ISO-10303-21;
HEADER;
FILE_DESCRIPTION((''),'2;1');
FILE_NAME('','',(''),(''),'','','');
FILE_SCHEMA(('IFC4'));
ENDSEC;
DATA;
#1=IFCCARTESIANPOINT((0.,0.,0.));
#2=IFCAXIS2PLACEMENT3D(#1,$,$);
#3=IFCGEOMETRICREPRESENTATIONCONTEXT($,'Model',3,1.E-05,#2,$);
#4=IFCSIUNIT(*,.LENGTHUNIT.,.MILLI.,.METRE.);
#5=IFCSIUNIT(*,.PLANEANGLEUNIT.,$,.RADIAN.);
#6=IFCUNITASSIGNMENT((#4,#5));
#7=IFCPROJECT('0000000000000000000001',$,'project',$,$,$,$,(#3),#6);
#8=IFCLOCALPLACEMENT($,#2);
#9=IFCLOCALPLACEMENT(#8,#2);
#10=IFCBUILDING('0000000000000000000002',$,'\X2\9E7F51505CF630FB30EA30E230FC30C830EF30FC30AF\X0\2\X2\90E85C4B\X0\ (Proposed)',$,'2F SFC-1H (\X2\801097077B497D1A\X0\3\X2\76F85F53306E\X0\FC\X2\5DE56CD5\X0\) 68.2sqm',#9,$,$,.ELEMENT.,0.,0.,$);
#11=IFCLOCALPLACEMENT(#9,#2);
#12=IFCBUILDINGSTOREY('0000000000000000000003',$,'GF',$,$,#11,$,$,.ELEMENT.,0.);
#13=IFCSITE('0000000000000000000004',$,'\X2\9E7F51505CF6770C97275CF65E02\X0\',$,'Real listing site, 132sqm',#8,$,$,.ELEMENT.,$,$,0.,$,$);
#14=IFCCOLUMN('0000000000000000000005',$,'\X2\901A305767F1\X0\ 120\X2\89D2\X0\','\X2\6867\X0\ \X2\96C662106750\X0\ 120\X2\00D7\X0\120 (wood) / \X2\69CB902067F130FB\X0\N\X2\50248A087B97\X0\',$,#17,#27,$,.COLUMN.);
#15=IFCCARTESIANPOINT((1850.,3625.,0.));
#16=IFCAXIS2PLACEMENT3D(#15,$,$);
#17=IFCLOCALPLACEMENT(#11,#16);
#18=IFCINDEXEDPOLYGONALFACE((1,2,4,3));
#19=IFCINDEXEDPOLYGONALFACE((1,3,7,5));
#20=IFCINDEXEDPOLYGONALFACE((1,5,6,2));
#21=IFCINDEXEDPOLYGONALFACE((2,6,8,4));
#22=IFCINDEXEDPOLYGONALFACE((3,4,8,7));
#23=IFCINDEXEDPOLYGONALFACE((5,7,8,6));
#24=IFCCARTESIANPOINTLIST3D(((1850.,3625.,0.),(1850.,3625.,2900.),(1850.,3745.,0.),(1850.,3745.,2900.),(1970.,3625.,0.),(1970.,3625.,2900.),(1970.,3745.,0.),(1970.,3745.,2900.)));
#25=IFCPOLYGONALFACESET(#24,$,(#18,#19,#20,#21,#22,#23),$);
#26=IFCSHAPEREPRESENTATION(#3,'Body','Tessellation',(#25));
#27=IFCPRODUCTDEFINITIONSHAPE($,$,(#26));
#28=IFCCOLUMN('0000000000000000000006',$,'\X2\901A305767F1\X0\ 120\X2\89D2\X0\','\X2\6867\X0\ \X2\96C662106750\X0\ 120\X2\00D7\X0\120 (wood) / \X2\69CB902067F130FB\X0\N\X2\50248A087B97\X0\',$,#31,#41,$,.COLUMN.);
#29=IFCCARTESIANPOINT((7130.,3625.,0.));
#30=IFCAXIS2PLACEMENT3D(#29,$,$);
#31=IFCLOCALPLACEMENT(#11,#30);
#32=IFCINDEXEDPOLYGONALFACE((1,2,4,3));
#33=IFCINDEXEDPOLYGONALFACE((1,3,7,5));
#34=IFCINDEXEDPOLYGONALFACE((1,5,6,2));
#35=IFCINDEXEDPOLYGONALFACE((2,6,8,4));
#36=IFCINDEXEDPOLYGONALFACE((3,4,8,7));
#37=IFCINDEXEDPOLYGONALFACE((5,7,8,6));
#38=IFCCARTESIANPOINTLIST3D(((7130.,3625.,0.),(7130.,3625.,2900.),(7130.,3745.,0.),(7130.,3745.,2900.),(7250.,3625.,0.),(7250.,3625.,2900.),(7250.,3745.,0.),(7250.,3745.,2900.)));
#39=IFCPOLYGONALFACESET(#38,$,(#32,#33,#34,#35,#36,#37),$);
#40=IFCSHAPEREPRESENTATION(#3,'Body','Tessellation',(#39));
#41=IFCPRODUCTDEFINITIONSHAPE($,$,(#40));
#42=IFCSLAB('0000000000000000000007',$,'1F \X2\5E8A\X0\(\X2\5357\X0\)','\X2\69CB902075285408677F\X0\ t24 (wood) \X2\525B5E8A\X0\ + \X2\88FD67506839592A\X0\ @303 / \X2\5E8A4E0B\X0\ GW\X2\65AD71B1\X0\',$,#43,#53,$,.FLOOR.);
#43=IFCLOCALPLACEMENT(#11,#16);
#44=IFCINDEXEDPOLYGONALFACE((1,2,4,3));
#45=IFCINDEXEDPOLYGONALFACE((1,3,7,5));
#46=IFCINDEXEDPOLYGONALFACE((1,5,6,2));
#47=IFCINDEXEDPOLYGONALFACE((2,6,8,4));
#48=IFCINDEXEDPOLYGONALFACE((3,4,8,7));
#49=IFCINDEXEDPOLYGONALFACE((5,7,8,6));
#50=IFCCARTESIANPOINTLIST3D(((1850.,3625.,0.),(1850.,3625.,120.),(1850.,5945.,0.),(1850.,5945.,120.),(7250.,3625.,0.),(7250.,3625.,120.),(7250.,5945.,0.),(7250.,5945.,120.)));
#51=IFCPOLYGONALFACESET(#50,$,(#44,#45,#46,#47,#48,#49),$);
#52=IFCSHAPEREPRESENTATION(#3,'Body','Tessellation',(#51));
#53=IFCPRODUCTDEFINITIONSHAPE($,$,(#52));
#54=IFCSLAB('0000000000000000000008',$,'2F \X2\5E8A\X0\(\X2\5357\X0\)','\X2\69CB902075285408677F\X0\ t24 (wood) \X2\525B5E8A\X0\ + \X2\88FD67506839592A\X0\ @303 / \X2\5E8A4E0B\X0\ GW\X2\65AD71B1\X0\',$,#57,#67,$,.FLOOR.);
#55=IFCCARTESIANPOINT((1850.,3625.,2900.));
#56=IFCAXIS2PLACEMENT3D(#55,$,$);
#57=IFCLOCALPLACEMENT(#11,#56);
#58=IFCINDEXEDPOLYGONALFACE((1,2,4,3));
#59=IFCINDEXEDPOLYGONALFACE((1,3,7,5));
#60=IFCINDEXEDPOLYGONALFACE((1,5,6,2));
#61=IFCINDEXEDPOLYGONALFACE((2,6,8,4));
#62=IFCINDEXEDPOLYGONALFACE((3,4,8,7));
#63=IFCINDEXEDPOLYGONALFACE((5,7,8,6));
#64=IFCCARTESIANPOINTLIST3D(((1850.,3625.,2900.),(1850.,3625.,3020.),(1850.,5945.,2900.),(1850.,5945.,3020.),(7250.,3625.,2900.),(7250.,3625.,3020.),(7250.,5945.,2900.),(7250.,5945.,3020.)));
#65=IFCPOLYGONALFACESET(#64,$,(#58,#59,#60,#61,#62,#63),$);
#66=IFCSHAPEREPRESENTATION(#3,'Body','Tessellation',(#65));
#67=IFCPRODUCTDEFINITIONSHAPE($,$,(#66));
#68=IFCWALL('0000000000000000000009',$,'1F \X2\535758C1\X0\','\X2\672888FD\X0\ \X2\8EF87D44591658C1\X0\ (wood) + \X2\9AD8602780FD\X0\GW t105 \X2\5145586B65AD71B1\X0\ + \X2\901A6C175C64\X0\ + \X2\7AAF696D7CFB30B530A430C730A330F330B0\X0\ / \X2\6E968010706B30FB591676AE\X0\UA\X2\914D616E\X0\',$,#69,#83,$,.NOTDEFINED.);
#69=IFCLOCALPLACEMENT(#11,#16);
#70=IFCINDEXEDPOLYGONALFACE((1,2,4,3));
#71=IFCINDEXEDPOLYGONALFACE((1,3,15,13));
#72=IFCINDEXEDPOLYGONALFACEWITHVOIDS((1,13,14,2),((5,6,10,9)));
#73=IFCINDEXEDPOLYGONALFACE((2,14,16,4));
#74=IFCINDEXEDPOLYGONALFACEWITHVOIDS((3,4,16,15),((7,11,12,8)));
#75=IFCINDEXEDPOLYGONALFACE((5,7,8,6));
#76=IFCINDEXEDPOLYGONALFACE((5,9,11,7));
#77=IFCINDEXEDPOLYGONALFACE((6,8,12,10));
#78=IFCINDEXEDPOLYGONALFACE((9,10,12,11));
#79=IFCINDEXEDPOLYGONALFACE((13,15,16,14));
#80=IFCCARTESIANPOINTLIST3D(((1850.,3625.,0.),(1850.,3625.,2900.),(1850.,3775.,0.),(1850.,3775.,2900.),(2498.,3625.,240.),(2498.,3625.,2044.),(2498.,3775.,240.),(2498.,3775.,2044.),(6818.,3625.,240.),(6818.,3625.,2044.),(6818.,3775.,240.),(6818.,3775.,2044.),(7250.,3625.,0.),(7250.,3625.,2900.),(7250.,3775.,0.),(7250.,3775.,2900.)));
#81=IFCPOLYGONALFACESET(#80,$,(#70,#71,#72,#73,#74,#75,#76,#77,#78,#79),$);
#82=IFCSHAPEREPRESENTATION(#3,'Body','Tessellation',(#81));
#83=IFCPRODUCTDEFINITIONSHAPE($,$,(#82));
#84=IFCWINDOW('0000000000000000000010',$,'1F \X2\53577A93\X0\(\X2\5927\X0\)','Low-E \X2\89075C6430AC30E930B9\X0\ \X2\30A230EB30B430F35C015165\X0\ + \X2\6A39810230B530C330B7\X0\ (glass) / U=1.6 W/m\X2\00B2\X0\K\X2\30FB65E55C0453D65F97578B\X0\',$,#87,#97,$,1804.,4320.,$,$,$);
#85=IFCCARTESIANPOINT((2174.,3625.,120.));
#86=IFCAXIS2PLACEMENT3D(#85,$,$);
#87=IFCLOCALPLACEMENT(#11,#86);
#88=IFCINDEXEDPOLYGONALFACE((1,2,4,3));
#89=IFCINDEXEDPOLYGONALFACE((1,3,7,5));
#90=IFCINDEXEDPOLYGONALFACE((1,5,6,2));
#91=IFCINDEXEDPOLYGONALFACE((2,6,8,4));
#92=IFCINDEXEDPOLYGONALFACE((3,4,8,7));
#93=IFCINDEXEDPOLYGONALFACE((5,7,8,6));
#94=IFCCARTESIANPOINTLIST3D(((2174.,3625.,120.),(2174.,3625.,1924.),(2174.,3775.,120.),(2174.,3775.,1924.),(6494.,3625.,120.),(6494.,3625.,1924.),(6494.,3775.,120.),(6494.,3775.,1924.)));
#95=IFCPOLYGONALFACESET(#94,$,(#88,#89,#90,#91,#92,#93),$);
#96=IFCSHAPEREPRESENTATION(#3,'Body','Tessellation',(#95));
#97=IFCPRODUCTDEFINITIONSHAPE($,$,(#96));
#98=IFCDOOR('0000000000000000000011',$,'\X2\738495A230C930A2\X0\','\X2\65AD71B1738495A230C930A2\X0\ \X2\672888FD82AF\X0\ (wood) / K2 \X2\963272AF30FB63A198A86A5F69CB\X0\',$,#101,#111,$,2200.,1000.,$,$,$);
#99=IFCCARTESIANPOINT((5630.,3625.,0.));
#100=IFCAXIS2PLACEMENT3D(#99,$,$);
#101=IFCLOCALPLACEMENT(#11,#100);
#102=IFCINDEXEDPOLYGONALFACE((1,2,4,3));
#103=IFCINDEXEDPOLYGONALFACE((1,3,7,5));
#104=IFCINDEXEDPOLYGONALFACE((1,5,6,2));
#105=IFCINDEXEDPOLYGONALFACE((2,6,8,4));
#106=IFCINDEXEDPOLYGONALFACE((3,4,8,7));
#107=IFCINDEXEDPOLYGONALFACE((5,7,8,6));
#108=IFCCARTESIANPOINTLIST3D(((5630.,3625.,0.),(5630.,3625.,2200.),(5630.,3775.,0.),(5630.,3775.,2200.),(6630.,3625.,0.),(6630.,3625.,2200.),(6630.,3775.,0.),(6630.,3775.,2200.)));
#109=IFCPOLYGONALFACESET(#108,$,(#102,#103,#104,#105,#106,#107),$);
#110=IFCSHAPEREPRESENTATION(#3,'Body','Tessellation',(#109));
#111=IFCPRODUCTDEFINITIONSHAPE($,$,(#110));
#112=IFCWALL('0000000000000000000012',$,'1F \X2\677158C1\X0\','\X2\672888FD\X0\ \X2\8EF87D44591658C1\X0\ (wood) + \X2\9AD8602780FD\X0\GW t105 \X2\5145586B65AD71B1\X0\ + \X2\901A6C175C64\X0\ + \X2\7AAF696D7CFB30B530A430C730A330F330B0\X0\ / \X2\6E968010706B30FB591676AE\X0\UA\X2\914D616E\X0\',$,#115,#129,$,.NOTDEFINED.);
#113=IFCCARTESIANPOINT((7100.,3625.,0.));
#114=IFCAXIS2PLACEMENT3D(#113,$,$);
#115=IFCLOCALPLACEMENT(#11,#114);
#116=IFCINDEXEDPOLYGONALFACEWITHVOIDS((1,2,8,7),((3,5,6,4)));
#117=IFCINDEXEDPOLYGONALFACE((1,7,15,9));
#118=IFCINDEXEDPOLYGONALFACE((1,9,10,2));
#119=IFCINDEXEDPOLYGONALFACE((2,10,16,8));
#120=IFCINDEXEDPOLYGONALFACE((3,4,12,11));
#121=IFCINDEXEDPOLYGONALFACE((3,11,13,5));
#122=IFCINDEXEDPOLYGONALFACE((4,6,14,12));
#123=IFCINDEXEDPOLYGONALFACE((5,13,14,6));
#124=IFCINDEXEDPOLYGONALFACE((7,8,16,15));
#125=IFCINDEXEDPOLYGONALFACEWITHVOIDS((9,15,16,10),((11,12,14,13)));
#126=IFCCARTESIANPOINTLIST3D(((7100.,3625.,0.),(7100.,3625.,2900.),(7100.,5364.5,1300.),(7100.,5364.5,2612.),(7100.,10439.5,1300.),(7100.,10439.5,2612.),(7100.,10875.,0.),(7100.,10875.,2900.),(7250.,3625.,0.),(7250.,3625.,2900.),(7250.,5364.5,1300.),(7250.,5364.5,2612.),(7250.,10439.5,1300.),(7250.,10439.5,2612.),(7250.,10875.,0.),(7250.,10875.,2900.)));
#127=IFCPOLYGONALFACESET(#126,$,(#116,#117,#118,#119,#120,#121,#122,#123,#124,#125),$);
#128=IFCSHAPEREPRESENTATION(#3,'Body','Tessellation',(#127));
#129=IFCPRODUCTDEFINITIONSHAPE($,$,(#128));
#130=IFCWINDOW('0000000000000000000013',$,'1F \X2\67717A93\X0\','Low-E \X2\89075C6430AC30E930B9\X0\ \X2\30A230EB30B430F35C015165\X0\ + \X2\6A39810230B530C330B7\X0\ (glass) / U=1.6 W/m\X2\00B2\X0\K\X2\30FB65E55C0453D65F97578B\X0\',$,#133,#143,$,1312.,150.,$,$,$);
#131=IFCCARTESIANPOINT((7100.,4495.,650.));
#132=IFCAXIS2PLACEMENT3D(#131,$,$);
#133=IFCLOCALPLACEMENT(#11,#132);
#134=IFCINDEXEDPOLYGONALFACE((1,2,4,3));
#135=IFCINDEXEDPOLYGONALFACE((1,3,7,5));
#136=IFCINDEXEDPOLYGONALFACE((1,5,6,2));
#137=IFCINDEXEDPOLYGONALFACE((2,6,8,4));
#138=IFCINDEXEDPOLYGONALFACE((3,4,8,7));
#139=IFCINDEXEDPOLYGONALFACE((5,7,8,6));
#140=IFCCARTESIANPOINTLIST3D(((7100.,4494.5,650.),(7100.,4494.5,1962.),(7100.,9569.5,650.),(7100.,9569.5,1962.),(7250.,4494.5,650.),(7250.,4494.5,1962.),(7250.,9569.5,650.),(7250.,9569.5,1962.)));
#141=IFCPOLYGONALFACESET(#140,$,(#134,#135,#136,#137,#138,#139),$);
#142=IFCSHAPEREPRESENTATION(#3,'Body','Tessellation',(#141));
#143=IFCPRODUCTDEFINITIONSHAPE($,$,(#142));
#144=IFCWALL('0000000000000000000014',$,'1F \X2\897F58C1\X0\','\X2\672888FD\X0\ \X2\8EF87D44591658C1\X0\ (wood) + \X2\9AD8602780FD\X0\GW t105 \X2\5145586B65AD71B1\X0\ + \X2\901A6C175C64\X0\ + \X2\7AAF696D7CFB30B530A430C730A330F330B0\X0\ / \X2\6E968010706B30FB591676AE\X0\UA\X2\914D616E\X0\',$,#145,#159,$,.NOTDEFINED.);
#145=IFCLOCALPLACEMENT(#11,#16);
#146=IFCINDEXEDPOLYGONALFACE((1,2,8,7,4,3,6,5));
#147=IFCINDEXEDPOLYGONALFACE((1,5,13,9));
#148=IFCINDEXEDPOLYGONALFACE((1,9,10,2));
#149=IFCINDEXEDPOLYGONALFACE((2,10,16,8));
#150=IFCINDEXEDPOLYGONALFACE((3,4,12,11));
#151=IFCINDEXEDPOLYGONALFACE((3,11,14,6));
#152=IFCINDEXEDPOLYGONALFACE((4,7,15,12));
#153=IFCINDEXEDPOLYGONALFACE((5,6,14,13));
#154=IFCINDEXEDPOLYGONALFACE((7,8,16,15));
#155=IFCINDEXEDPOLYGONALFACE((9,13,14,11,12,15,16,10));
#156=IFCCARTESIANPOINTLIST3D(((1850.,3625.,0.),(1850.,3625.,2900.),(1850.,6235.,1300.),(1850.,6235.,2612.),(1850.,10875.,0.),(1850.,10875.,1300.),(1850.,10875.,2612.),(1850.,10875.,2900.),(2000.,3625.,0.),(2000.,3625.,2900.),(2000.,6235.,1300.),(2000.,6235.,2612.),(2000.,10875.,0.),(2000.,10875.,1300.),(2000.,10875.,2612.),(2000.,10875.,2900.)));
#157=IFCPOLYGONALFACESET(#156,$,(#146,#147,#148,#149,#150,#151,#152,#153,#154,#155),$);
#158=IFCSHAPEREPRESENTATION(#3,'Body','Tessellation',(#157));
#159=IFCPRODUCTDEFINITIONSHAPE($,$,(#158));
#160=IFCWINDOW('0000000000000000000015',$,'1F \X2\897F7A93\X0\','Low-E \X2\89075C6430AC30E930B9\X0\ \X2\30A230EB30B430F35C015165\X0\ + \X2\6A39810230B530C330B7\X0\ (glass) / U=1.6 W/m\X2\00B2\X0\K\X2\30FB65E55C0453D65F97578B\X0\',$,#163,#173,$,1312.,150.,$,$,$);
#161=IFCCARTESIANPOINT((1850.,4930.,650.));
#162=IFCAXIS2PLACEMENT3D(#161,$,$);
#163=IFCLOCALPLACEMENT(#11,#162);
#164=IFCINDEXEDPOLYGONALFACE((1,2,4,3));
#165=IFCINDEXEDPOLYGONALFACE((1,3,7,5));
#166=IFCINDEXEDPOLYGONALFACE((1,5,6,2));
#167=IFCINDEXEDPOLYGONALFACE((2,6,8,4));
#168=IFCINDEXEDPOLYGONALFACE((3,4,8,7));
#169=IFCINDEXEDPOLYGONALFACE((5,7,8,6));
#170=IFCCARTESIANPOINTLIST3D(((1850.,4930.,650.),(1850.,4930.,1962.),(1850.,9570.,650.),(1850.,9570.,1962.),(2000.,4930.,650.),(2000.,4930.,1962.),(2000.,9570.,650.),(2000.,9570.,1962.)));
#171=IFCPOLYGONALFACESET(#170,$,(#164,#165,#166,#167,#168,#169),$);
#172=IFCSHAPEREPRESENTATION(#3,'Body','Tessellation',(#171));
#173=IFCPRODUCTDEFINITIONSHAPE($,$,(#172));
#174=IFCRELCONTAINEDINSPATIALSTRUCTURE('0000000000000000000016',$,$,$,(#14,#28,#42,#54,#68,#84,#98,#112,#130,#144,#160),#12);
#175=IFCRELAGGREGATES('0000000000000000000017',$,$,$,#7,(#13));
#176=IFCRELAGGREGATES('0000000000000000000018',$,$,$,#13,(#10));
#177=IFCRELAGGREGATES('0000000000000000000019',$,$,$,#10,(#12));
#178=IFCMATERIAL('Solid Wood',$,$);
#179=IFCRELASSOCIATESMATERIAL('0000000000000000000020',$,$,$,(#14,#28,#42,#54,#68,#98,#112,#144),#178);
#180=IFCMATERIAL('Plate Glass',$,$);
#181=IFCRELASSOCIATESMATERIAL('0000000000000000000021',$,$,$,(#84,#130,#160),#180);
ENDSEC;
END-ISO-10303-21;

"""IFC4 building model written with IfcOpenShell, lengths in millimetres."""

from ifc_helpers import new_model, si_unit, frame, frame_2d, origin, place, context, project, spatial, rectangle, extrude, material, element, fill, save


model = new_model("IFC4")

# Units and contexts
model_context = context("Model", 3, precision=1e-05, world=origin())
ifc_project = project(units=[si_unit("LENGTHUNIT", "METRE", prefix="MILLI"), si_unit("PLANEANGLEUNIT", "RADIAN")], contexts=[model_context])

# Site, building, storey
site_placement = place(None, origin())
site = spatial("IfcSite", under=ifc_project, at=site_placement, Name="鹿児島県霧島市", ObjectType="Real listing site, 132sqm", CompositionType="ELEMENT", RefElevation=0.0)
building_placement = place(site_placement, origin())
building = spatial("IfcBuilding", under=site, at=building_placement, Name="鹿児島・リモートワーク2部屋 (Proposed)", ObjectType="2F SFC-1H (耐震等級3相当のFC工法) 68.2sqm", CompositionType="ELEMENT", ElevationOfRefHeight=0.0, ElevationOfTerrain=0.0)
storey_placement = place(building_placement, origin())
storey = spatial("IfcBuildingStorey", under=building, at=storey_placement, Name="GF", CompositionType="ELEMENT", Elevation=0.0)

# Columns
ifc_material_1 = material(Name="Solid Wood")
column_1_placement = place(storey_placement, frame((1850.0, 3625.0, 0.0)))
element("IfcColumn", 1, at=column_1_placement, inside=storey, material=ifc_material_1, Name="通し柱 120角", Description="桧 集成材 120×120 (wood) / 構造柱・N値計算", PredefinedType="COLUMN", context=model_context, shape_type="SweptSolid", body=[
    extrude(rectangle(XDim=120.0, YDim=120.0, at=frame_2d((60.0, 60.0))), frame((1850.0, 3625.0, 0.0)), (0.0, 0.0, 1.0), 2900.0),
])
column_2_placement = place(storey_placement, frame((7130.0, 3625.0, 0.0)))
element("IfcColumn", 2, at=column_2_placement, inside=storey, material=ifc_material_1, Name="通し柱 120角", Description="桧 集成材 120×120 (wood) / 構造柱・N値計算", PredefinedType="COLUMN", context=model_context, shape_type="SweptSolid", body=[
    extrude(rectangle(XDim=120.0, YDim=120.0, at=frame_2d((60.0, 60.0))), frame((7130.0, 3625.0, 0.0)), (0.0, 0.0, 1.0), 2900.0),
])

# Slabs
slab_1_placement = place(storey_placement, frame((1850.0, 3625.0, 0.0)))
element("IfcSlab", 3, at=slab_1_placement, inside=storey, material=ifc_material_1, Name="1F 床(南)", Description="構造用合板 t24 (wood) 剛床 + 製材根太 @303 / 床下 GW断熱", PredefinedType="FLOOR", context=model_context, shape_type="SweptSolid", body=[
    extrude(rectangle(XDim=5400.0, YDim=2320.0, at=frame_2d((2700.0, 1160.0))), frame((1850.0, 3625.0, 0.0)), (0.0, 0.0, 1.0), 120.0),
])
slab_2_placement = place(storey_placement, frame((1850.0, 3625.0, 2900.0)))
element("IfcSlab", 4, at=slab_2_placement, inside=storey, material=ifc_material_1, Name="2F 床(南)", Description="構造用合板 t24 (wood) 剛床 + 製材根太 @303 / 床下 GW断熱", PredefinedType="FLOOR", context=model_context, shape_type="SweptSolid", body=[
    extrude(rectangle(XDim=5400.0, YDim=2320.0, at=frame_2d((2700.0, 1160.0))), frame((1850.0, 3625.0, 2900.0)), (0.0, 0.0, 1.0), 120.0),
])

# Wall, openings, window, door
wall_1_placement = place(storey_placement, frame((1850.0, 3625.0, 0.0)))
wall_1 = element("IfcWall", 5, at=wall_1_placement, inside=storey, material=ifc_material_1, Name="1F 南壁", Description="木製 軸組外壁 (wood) + 高性能GW t105 充填断熱 + 通気層 + 窯業系サイディング / 準耐火・外皮UA配慮", PredefinedType="NOTDEFINED", context=model_context, shape_type="SweptSolid", body=[
    extrude(rectangle(XDim=5400.0, YDim=150.0, at=frame_2d((2700.0, 75.0))), frame((1850.0, 3625.0, 0.0)), (0.0, 0.0, 1.0), 2900.0),
])
opening_1_placement = place(storey_placement, frame((2174.0, 3625.0, 120.0)))
opening_1 = element("IfcOpeningElement", 6, at=opening_1_placement, cuts=wall_1, PredefinedType="NOTDEFINED", context=model_context, shape_type="SweptSolid", body=[
    extrude(rectangle(XDim=4320.0, YDim=150.0, at=frame_2d((2160.0, 75.0))), frame((2174.0, 3625.0, 120.0)), (0.0, 0.0, 1.0), 1804.0),
])
opening_2_placement = place(storey_placement, frame((5630.0, 3625.0, 0.0)))
opening_2 = element("IfcOpeningElement", 7, at=opening_2_placement, cuts=wall_1, PredefinedType="NOTDEFINED", context=model_context, shape_type="SweptSolid", body=[
    extrude(rectangle(XDim=1000.0, YDim=150.0, at=frame_2d((500.0, 75.0))), frame((5630.0, 3625.0, 0.0)), (0.0, 0.0, 1.0), 2200.0),
])
ifc_material_2 = material(Name="Plate Glass")
window_1_placement = place(storey_placement, frame((2174.0, 3625.0, 120.0)))
window_1 = element("IfcWindow", 8, at=window_1_placement, inside=storey, material=ifc_material_2, Name="1F 南窓(大)", Description="Low-E 複層ガラス アルゴン封入 + 樹脂サッシ (glass) / U=1.6 W/m²K・日射取得型", OverallHeight=1804.0, OverallWidth=4320.0, context=model_context, shape_type="SweptSolid", body=[
    extrude(rectangle(XDim=4320.0, YDim=150.0, at=frame_2d((2160.0, 75.0))), frame((2174.0, 3625.0, 120.0)), (0.0, 0.0, 1.0), 1804.0),
])
fill(opening_1, window_1)
door_placement = place(storey_placement, frame((5630.0, 3625.0, 0.0)))
door = element("IfcDoor", 9, at=door_placement, inside=storey, material=ifc_material_1, Name="玄関ドア", Description="断熱玄関ドア 木製芯 (wood) / K2 防犯・採風機構", OverallHeight=2200.0, OverallWidth=1000.0, context=model_context, shape_type="SweptSolid", body=[
    extrude(rectangle(XDim=1000.0, YDim=150.0, at=frame_2d((500.0, 75.0))), frame((5630.0, 3625.0, 0.0)), (0.0, 0.0, 1.0), 2200.0),
])
fill(opening_2, door)

# Walls, openings, windows
wall_2_placement = place(storey_placement, frame((7100.0, 3625.0, 0.0)))
wall_2 = element("IfcWall", 10, at=wall_2_placement, inside=storey, material=ifc_material_1, Name="1F 東壁", Description="木製 軸組外壁 (wood) + 高性能GW t105 充填断熱 + 通気層 + 窯業系サイディング / 準耐火・外皮UA配慮", PredefinedType="NOTDEFINED", context=model_context, shape_type="SweptSolid", body=[
    extrude(rectangle(XDim=150.0, YDim=7250.0, at=frame_2d((75.0, 3625.0))), frame((7100.0, 3625.0, 0.0)), (0.0, 0.0, 1.0), 2900.0),
])
opening_3_placement = place(storey_placement, frame((7100.0, 4495.0, 650.0)))
opening_3 = element("IfcOpeningElement", 11, at=opening_3_placement, cuts=wall_2, PredefinedType="NOTDEFINED", context=model_context, shape_type="SweptSolid", body=[
    extrude(rectangle(XDim=150.0, YDim=5075.0, at=frame_2d((75.0, 2537.0))), frame((7100.0, 4495.0, 650.0)), (0.0, 0.0, 1.0), 1312.0),
])
window_2_placement = place(storey_placement, frame((7100.0, 4495.0, 650.0)))
window_2 = element("IfcWindow", 12, at=window_2_placement, inside=storey, material=ifc_material_2, Name="1F 東窓", Description="Low-E 複層ガラス アルゴン封入 + 樹脂サッシ (glass) / U=1.6 W/m²K・日射取得型", OverallHeight=1312.0, OverallWidth=150.0, context=model_context, shape_type="SweptSolid", body=[
    extrude(rectangle(XDim=150.0, YDim=5075.0, at=frame_2d((75.0, 2537.0))), frame((7100.0, 4495.0, 650.0)), (0.0, 0.0, 1.0), 1312.0),
])
fill(opening_3, window_2)
wall_3_placement = place(storey_placement, frame((1850.0, 3625.0, 0.0)))
wall_3 = element("IfcWall", 13, at=wall_3_placement, inside=storey, material=ifc_material_1, Name="1F 西壁", Description="木製 軸組外壁 (wood) + 高性能GW t105 充填断熱 + 通気層 + 窯業系サイディング / 準耐火・外皮UA配慮", PredefinedType="NOTDEFINED", context=model_context, shape_type="SweptSolid", body=[
    extrude(rectangle(XDim=150.0, YDim=7250.0, at=frame_2d((75.0, 3625.0))), frame((1850.0, 3625.0, 0.0)), (0.0, 0.0, 1.0), 2900.0),
])
opening_4_placement = place(storey_placement, frame((1850.0, 4930.0, 650.0)))
opening_4 = element("IfcOpeningElement", 14, at=opening_4_placement, cuts=wall_3, PredefinedType="NOTDEFINED", context=model_context, shape_type="SweptSolid", body=[
    extrude(rectangle(XDim=150.0, YDim=4640.0, at=frame_2d((75.0, 2320.0))), frame((1850.0, 4930.0, 650.0)), (0.0, 0.0, 1.0), 1312.0),
])
window_3_placement = place(storey_placement, frame((1850.0, 4930.0, 650.0)))
window_3 = element("IfcWindow", 15, at=window_3_placement, inside=storey, material=ifc_material_2, Name="1F 西窓", Description="Low-E 複層ガラス アルゴン封入 + 樹脂サッシ (glass) / U=1.6 W/m²K・日射取得型", OverallHeight=1312.0, OverallWidth=150.0, context=model_context, shape_type="SweptSolid", body=[
    extrude(rectangle(XDim=150.0, YDim=4640.0, at=frame_2d((75.0, 2320.0))), frame((1850.0, 4930.0, 650.0)), (0.0, 0.0, 1.0), 1312.0),
])
fill(opening_4, window_3)

save(model, "model.ifc")
